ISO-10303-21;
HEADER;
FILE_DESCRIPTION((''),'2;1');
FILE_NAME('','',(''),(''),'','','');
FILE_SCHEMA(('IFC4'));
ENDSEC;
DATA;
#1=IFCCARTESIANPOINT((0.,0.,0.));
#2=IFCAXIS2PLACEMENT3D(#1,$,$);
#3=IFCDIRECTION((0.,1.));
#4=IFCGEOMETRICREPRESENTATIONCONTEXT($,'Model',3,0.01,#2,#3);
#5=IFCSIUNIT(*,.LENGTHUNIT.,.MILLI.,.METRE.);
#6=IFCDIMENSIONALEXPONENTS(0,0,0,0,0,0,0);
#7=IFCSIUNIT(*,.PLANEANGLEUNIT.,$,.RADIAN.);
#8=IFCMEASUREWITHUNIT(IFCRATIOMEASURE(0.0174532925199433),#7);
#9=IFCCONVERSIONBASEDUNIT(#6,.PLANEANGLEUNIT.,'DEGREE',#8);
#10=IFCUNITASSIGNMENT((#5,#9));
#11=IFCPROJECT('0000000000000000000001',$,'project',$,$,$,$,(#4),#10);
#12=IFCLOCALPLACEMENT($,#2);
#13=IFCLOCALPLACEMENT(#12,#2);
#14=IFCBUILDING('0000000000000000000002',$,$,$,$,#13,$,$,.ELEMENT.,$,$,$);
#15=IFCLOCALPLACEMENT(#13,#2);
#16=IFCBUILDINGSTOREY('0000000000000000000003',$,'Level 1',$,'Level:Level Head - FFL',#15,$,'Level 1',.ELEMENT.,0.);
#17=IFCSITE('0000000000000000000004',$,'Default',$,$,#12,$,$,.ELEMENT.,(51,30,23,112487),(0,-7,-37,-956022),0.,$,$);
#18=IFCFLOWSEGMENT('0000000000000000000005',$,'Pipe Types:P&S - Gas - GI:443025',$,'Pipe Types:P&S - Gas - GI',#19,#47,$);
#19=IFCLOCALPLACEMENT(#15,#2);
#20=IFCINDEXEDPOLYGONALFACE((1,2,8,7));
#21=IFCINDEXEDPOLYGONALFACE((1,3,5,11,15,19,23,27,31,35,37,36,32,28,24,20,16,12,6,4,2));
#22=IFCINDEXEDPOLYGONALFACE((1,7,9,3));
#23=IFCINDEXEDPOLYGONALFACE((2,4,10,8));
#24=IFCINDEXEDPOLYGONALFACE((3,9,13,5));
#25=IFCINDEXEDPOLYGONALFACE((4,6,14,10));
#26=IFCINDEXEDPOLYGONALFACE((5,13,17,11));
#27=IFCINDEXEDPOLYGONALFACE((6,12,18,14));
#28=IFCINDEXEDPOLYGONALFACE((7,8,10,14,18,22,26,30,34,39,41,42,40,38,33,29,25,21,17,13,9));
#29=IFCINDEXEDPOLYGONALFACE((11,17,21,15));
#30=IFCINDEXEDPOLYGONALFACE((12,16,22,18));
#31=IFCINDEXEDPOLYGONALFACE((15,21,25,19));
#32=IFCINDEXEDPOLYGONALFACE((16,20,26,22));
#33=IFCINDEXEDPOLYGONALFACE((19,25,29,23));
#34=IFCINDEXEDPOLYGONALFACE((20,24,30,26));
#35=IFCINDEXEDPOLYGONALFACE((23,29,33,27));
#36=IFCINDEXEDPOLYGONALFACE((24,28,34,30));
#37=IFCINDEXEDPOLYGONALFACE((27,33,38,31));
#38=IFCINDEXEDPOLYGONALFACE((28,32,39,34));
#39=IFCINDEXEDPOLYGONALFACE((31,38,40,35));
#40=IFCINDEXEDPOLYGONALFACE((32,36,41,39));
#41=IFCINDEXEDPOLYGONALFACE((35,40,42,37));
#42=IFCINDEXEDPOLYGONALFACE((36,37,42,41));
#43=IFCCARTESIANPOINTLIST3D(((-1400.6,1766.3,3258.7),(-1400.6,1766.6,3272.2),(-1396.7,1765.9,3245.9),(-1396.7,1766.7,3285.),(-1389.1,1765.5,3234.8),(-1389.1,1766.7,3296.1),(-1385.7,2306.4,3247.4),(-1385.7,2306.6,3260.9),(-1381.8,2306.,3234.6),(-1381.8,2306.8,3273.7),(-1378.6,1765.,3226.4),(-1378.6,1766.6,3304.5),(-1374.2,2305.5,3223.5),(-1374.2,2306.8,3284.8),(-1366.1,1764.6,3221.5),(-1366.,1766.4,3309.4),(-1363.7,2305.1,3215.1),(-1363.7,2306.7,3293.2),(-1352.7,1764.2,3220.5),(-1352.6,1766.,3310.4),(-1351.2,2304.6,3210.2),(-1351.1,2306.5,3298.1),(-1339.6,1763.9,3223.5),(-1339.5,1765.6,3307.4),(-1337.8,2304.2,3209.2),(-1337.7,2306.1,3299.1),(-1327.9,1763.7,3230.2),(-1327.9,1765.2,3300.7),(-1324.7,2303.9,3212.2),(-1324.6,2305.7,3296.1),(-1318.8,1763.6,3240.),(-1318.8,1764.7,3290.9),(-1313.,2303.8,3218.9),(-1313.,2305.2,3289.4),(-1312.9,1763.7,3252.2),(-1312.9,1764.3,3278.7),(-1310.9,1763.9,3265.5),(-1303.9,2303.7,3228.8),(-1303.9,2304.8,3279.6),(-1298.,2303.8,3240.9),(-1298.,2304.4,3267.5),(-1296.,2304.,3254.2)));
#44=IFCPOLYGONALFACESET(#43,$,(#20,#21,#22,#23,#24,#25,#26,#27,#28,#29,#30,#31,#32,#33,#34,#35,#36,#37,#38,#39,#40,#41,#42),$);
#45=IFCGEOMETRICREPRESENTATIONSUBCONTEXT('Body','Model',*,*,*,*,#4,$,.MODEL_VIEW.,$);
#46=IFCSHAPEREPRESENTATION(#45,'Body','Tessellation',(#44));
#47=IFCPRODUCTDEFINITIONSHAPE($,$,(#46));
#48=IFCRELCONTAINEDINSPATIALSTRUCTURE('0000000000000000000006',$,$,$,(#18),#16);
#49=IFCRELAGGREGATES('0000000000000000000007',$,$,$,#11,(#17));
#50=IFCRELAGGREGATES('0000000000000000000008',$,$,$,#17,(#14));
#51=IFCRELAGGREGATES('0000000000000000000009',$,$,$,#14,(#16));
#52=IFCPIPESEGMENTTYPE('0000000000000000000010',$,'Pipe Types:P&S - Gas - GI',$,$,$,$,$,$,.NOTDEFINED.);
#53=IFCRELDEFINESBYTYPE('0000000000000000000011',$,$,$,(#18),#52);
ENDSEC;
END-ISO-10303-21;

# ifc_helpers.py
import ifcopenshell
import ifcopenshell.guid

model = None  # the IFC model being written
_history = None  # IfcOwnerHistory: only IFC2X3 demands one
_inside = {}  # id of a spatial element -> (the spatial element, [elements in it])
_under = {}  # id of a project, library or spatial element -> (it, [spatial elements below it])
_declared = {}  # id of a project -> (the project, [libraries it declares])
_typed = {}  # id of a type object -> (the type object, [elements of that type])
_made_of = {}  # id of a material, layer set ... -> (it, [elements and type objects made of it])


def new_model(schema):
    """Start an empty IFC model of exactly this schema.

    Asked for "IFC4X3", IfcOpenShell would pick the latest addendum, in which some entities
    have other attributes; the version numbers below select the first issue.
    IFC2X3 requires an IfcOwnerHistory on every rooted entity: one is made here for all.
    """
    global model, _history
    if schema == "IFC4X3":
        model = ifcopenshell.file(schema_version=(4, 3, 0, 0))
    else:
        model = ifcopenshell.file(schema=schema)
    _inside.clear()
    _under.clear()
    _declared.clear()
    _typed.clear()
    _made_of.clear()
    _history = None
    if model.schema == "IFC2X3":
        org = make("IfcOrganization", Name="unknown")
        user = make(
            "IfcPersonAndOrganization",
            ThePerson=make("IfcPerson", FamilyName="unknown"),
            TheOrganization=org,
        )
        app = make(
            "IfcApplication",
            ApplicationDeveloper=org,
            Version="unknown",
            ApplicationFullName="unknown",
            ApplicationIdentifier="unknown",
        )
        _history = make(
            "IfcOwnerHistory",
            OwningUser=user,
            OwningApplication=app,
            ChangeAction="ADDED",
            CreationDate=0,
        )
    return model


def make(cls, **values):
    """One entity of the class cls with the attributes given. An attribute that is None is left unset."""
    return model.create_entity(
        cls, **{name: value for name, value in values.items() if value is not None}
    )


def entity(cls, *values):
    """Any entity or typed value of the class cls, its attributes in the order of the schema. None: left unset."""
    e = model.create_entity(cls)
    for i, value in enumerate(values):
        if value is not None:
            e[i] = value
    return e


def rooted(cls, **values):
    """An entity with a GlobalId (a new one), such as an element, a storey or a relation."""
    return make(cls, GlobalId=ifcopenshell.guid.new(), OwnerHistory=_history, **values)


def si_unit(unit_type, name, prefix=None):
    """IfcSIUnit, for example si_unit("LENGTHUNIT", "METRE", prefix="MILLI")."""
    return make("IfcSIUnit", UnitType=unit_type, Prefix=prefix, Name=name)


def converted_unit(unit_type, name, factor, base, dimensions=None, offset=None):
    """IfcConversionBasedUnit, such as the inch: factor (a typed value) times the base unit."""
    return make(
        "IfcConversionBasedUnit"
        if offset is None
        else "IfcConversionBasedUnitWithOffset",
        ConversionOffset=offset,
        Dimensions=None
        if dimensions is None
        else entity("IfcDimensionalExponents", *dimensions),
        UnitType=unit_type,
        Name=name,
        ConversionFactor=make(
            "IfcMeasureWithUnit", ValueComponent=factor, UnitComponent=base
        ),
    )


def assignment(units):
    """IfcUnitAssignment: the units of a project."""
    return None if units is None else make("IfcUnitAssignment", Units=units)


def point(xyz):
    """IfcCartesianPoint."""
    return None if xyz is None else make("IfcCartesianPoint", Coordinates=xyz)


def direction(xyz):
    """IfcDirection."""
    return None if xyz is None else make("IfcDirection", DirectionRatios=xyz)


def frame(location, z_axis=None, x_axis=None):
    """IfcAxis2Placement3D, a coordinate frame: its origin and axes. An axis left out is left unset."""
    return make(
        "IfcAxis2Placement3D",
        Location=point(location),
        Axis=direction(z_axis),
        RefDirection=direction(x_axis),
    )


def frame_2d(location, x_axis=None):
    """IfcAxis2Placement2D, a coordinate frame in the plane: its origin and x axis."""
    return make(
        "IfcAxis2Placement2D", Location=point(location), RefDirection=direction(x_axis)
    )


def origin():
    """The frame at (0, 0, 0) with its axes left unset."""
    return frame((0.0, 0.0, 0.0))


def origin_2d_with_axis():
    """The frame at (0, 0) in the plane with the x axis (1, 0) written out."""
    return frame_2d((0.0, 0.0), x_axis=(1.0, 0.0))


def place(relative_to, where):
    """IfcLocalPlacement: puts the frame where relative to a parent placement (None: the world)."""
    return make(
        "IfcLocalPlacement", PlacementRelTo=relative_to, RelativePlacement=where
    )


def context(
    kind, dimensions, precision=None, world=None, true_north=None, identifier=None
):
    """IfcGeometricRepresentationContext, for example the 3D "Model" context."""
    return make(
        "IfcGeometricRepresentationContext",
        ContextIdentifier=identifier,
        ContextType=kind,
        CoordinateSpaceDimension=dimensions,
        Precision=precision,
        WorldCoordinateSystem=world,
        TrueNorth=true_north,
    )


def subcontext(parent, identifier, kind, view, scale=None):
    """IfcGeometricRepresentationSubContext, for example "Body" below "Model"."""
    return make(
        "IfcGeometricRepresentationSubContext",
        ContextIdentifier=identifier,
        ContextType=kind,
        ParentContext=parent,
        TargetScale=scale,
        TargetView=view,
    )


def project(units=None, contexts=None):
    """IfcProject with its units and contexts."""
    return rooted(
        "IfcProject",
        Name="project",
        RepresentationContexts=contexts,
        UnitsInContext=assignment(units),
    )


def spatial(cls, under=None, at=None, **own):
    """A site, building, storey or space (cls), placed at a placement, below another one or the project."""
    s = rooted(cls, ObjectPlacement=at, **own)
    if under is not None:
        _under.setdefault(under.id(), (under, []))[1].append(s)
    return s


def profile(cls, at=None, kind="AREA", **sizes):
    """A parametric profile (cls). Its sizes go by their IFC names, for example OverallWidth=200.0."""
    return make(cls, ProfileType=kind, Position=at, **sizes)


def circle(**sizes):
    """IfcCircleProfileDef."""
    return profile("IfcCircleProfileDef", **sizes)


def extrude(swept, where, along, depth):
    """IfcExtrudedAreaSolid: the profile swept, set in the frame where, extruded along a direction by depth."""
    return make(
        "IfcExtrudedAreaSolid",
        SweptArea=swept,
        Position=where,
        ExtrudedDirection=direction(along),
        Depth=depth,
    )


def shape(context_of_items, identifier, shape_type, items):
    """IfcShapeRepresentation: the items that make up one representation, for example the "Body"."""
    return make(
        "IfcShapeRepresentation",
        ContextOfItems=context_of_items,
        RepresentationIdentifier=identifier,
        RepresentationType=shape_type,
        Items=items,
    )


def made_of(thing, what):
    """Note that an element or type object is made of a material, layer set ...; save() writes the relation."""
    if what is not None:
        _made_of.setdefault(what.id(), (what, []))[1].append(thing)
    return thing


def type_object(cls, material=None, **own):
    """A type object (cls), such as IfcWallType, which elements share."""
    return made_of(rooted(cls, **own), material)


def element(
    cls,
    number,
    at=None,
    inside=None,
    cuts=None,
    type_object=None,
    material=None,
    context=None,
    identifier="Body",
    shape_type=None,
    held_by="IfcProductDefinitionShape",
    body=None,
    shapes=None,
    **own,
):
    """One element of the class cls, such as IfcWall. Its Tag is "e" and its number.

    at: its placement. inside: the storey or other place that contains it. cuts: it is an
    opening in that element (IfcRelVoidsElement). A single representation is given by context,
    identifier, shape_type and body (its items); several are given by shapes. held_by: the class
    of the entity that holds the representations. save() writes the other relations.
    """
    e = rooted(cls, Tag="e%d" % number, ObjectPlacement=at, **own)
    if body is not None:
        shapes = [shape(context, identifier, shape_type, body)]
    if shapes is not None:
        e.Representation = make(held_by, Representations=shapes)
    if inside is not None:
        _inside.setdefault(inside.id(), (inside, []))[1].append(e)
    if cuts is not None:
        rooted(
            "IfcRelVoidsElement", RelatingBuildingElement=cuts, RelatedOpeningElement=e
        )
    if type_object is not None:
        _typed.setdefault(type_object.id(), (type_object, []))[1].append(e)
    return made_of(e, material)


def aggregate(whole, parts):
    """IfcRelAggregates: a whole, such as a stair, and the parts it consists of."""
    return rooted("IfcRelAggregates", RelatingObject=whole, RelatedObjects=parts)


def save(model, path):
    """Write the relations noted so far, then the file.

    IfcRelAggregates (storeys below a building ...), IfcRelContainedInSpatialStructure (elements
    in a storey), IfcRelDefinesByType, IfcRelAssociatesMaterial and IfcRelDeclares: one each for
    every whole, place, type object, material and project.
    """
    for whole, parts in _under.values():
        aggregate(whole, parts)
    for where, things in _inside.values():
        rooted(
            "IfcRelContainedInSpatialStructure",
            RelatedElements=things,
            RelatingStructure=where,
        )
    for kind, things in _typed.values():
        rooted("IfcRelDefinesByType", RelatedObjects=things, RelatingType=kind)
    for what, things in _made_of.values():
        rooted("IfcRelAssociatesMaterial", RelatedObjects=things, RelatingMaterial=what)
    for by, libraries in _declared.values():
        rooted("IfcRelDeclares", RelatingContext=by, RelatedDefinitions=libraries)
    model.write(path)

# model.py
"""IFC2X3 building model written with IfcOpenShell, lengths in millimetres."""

from ifc_helpers import new_model, entity, si_unit, converted_unit, direction, frame, origin, origin_2d_with_axis, place, context, subcontext, project, spatial, circle, extrude, type_object, element, save


model = new_model("IFC2X3")

# Units and contexts
model_context = context("Model", 3, precision=0.01, world=origin(), true_north=direction((0.0, 1.0)))
body_context = subcontext(model_context, "Body", "Model", "MODEL_VIEW")
ifc_project = project(units=[si_unit("LENGTHUNIT", "METRE", prefix="MILLI"), converted_unit("PLANEANGLEUNIT", "DEGREE", entity("IfcRatioMeasure", 0.0174532925199433), si_unit("PLANEANGLEUNIT", "RADIAN"), dimensions=[0, 0, 0, 0, 0, 0, 0])], contexts=[model_context])

# Site, building, storey
site_placement = place(None, origin())
site = spatial("IfcSite", under=ifc_project, at=site_placement, Name="Default", CompositionType="ELEMENT", RefLatitude=(51, 30, 23, 112487), RefLongitude=(0, -7, -37, -956022), RefElevation=0.0)
building_placement = place(site_placement, origin())
building = spatial("IfcBuilding", under=site, at=building_placement, CompositionType="ELEMENT")
storey_placement = place(building_placement, origin())
storey = spatial("IfcBuildingStorey", under=building, at=storey_placement, Name="Level 1", ObjectType="Level:Level Head - FFL", LongName="Level 1", CompositionType="ELEMENT", Elevation=0.0)

# Flow segment
pipe_segment_type = type_object("IfcPipeSegmentType", Name="Pipe Types:P&S - Gas - GI", PredefinedType="NOTDEFINED")
flow_segment_1_placement = place(storey_placement, origin())
element("IfcFlowSegment", 1, at=flow_segment_1_placement, inside=storey, type_object=pipe_segment_type, Name="Pipe Types:P&S - Gas - GI:443025", ObjectType="Pipe Types:P&S - Gas - GI", context=body_context, shape_type="SweptSolid", body=[
    extrude(circle(Radius=45.1, at=origin_2d_with_axis()), frame((-1341.1, 2305.3, 3254.2), z_axis=(-0.027574, -0.999401, 0.020897), x_axis=(0.99962, -0.02758, 0.0)), (0.0, 0.0, 1.0), 540.4),
])

save(model, "model.ifc")
